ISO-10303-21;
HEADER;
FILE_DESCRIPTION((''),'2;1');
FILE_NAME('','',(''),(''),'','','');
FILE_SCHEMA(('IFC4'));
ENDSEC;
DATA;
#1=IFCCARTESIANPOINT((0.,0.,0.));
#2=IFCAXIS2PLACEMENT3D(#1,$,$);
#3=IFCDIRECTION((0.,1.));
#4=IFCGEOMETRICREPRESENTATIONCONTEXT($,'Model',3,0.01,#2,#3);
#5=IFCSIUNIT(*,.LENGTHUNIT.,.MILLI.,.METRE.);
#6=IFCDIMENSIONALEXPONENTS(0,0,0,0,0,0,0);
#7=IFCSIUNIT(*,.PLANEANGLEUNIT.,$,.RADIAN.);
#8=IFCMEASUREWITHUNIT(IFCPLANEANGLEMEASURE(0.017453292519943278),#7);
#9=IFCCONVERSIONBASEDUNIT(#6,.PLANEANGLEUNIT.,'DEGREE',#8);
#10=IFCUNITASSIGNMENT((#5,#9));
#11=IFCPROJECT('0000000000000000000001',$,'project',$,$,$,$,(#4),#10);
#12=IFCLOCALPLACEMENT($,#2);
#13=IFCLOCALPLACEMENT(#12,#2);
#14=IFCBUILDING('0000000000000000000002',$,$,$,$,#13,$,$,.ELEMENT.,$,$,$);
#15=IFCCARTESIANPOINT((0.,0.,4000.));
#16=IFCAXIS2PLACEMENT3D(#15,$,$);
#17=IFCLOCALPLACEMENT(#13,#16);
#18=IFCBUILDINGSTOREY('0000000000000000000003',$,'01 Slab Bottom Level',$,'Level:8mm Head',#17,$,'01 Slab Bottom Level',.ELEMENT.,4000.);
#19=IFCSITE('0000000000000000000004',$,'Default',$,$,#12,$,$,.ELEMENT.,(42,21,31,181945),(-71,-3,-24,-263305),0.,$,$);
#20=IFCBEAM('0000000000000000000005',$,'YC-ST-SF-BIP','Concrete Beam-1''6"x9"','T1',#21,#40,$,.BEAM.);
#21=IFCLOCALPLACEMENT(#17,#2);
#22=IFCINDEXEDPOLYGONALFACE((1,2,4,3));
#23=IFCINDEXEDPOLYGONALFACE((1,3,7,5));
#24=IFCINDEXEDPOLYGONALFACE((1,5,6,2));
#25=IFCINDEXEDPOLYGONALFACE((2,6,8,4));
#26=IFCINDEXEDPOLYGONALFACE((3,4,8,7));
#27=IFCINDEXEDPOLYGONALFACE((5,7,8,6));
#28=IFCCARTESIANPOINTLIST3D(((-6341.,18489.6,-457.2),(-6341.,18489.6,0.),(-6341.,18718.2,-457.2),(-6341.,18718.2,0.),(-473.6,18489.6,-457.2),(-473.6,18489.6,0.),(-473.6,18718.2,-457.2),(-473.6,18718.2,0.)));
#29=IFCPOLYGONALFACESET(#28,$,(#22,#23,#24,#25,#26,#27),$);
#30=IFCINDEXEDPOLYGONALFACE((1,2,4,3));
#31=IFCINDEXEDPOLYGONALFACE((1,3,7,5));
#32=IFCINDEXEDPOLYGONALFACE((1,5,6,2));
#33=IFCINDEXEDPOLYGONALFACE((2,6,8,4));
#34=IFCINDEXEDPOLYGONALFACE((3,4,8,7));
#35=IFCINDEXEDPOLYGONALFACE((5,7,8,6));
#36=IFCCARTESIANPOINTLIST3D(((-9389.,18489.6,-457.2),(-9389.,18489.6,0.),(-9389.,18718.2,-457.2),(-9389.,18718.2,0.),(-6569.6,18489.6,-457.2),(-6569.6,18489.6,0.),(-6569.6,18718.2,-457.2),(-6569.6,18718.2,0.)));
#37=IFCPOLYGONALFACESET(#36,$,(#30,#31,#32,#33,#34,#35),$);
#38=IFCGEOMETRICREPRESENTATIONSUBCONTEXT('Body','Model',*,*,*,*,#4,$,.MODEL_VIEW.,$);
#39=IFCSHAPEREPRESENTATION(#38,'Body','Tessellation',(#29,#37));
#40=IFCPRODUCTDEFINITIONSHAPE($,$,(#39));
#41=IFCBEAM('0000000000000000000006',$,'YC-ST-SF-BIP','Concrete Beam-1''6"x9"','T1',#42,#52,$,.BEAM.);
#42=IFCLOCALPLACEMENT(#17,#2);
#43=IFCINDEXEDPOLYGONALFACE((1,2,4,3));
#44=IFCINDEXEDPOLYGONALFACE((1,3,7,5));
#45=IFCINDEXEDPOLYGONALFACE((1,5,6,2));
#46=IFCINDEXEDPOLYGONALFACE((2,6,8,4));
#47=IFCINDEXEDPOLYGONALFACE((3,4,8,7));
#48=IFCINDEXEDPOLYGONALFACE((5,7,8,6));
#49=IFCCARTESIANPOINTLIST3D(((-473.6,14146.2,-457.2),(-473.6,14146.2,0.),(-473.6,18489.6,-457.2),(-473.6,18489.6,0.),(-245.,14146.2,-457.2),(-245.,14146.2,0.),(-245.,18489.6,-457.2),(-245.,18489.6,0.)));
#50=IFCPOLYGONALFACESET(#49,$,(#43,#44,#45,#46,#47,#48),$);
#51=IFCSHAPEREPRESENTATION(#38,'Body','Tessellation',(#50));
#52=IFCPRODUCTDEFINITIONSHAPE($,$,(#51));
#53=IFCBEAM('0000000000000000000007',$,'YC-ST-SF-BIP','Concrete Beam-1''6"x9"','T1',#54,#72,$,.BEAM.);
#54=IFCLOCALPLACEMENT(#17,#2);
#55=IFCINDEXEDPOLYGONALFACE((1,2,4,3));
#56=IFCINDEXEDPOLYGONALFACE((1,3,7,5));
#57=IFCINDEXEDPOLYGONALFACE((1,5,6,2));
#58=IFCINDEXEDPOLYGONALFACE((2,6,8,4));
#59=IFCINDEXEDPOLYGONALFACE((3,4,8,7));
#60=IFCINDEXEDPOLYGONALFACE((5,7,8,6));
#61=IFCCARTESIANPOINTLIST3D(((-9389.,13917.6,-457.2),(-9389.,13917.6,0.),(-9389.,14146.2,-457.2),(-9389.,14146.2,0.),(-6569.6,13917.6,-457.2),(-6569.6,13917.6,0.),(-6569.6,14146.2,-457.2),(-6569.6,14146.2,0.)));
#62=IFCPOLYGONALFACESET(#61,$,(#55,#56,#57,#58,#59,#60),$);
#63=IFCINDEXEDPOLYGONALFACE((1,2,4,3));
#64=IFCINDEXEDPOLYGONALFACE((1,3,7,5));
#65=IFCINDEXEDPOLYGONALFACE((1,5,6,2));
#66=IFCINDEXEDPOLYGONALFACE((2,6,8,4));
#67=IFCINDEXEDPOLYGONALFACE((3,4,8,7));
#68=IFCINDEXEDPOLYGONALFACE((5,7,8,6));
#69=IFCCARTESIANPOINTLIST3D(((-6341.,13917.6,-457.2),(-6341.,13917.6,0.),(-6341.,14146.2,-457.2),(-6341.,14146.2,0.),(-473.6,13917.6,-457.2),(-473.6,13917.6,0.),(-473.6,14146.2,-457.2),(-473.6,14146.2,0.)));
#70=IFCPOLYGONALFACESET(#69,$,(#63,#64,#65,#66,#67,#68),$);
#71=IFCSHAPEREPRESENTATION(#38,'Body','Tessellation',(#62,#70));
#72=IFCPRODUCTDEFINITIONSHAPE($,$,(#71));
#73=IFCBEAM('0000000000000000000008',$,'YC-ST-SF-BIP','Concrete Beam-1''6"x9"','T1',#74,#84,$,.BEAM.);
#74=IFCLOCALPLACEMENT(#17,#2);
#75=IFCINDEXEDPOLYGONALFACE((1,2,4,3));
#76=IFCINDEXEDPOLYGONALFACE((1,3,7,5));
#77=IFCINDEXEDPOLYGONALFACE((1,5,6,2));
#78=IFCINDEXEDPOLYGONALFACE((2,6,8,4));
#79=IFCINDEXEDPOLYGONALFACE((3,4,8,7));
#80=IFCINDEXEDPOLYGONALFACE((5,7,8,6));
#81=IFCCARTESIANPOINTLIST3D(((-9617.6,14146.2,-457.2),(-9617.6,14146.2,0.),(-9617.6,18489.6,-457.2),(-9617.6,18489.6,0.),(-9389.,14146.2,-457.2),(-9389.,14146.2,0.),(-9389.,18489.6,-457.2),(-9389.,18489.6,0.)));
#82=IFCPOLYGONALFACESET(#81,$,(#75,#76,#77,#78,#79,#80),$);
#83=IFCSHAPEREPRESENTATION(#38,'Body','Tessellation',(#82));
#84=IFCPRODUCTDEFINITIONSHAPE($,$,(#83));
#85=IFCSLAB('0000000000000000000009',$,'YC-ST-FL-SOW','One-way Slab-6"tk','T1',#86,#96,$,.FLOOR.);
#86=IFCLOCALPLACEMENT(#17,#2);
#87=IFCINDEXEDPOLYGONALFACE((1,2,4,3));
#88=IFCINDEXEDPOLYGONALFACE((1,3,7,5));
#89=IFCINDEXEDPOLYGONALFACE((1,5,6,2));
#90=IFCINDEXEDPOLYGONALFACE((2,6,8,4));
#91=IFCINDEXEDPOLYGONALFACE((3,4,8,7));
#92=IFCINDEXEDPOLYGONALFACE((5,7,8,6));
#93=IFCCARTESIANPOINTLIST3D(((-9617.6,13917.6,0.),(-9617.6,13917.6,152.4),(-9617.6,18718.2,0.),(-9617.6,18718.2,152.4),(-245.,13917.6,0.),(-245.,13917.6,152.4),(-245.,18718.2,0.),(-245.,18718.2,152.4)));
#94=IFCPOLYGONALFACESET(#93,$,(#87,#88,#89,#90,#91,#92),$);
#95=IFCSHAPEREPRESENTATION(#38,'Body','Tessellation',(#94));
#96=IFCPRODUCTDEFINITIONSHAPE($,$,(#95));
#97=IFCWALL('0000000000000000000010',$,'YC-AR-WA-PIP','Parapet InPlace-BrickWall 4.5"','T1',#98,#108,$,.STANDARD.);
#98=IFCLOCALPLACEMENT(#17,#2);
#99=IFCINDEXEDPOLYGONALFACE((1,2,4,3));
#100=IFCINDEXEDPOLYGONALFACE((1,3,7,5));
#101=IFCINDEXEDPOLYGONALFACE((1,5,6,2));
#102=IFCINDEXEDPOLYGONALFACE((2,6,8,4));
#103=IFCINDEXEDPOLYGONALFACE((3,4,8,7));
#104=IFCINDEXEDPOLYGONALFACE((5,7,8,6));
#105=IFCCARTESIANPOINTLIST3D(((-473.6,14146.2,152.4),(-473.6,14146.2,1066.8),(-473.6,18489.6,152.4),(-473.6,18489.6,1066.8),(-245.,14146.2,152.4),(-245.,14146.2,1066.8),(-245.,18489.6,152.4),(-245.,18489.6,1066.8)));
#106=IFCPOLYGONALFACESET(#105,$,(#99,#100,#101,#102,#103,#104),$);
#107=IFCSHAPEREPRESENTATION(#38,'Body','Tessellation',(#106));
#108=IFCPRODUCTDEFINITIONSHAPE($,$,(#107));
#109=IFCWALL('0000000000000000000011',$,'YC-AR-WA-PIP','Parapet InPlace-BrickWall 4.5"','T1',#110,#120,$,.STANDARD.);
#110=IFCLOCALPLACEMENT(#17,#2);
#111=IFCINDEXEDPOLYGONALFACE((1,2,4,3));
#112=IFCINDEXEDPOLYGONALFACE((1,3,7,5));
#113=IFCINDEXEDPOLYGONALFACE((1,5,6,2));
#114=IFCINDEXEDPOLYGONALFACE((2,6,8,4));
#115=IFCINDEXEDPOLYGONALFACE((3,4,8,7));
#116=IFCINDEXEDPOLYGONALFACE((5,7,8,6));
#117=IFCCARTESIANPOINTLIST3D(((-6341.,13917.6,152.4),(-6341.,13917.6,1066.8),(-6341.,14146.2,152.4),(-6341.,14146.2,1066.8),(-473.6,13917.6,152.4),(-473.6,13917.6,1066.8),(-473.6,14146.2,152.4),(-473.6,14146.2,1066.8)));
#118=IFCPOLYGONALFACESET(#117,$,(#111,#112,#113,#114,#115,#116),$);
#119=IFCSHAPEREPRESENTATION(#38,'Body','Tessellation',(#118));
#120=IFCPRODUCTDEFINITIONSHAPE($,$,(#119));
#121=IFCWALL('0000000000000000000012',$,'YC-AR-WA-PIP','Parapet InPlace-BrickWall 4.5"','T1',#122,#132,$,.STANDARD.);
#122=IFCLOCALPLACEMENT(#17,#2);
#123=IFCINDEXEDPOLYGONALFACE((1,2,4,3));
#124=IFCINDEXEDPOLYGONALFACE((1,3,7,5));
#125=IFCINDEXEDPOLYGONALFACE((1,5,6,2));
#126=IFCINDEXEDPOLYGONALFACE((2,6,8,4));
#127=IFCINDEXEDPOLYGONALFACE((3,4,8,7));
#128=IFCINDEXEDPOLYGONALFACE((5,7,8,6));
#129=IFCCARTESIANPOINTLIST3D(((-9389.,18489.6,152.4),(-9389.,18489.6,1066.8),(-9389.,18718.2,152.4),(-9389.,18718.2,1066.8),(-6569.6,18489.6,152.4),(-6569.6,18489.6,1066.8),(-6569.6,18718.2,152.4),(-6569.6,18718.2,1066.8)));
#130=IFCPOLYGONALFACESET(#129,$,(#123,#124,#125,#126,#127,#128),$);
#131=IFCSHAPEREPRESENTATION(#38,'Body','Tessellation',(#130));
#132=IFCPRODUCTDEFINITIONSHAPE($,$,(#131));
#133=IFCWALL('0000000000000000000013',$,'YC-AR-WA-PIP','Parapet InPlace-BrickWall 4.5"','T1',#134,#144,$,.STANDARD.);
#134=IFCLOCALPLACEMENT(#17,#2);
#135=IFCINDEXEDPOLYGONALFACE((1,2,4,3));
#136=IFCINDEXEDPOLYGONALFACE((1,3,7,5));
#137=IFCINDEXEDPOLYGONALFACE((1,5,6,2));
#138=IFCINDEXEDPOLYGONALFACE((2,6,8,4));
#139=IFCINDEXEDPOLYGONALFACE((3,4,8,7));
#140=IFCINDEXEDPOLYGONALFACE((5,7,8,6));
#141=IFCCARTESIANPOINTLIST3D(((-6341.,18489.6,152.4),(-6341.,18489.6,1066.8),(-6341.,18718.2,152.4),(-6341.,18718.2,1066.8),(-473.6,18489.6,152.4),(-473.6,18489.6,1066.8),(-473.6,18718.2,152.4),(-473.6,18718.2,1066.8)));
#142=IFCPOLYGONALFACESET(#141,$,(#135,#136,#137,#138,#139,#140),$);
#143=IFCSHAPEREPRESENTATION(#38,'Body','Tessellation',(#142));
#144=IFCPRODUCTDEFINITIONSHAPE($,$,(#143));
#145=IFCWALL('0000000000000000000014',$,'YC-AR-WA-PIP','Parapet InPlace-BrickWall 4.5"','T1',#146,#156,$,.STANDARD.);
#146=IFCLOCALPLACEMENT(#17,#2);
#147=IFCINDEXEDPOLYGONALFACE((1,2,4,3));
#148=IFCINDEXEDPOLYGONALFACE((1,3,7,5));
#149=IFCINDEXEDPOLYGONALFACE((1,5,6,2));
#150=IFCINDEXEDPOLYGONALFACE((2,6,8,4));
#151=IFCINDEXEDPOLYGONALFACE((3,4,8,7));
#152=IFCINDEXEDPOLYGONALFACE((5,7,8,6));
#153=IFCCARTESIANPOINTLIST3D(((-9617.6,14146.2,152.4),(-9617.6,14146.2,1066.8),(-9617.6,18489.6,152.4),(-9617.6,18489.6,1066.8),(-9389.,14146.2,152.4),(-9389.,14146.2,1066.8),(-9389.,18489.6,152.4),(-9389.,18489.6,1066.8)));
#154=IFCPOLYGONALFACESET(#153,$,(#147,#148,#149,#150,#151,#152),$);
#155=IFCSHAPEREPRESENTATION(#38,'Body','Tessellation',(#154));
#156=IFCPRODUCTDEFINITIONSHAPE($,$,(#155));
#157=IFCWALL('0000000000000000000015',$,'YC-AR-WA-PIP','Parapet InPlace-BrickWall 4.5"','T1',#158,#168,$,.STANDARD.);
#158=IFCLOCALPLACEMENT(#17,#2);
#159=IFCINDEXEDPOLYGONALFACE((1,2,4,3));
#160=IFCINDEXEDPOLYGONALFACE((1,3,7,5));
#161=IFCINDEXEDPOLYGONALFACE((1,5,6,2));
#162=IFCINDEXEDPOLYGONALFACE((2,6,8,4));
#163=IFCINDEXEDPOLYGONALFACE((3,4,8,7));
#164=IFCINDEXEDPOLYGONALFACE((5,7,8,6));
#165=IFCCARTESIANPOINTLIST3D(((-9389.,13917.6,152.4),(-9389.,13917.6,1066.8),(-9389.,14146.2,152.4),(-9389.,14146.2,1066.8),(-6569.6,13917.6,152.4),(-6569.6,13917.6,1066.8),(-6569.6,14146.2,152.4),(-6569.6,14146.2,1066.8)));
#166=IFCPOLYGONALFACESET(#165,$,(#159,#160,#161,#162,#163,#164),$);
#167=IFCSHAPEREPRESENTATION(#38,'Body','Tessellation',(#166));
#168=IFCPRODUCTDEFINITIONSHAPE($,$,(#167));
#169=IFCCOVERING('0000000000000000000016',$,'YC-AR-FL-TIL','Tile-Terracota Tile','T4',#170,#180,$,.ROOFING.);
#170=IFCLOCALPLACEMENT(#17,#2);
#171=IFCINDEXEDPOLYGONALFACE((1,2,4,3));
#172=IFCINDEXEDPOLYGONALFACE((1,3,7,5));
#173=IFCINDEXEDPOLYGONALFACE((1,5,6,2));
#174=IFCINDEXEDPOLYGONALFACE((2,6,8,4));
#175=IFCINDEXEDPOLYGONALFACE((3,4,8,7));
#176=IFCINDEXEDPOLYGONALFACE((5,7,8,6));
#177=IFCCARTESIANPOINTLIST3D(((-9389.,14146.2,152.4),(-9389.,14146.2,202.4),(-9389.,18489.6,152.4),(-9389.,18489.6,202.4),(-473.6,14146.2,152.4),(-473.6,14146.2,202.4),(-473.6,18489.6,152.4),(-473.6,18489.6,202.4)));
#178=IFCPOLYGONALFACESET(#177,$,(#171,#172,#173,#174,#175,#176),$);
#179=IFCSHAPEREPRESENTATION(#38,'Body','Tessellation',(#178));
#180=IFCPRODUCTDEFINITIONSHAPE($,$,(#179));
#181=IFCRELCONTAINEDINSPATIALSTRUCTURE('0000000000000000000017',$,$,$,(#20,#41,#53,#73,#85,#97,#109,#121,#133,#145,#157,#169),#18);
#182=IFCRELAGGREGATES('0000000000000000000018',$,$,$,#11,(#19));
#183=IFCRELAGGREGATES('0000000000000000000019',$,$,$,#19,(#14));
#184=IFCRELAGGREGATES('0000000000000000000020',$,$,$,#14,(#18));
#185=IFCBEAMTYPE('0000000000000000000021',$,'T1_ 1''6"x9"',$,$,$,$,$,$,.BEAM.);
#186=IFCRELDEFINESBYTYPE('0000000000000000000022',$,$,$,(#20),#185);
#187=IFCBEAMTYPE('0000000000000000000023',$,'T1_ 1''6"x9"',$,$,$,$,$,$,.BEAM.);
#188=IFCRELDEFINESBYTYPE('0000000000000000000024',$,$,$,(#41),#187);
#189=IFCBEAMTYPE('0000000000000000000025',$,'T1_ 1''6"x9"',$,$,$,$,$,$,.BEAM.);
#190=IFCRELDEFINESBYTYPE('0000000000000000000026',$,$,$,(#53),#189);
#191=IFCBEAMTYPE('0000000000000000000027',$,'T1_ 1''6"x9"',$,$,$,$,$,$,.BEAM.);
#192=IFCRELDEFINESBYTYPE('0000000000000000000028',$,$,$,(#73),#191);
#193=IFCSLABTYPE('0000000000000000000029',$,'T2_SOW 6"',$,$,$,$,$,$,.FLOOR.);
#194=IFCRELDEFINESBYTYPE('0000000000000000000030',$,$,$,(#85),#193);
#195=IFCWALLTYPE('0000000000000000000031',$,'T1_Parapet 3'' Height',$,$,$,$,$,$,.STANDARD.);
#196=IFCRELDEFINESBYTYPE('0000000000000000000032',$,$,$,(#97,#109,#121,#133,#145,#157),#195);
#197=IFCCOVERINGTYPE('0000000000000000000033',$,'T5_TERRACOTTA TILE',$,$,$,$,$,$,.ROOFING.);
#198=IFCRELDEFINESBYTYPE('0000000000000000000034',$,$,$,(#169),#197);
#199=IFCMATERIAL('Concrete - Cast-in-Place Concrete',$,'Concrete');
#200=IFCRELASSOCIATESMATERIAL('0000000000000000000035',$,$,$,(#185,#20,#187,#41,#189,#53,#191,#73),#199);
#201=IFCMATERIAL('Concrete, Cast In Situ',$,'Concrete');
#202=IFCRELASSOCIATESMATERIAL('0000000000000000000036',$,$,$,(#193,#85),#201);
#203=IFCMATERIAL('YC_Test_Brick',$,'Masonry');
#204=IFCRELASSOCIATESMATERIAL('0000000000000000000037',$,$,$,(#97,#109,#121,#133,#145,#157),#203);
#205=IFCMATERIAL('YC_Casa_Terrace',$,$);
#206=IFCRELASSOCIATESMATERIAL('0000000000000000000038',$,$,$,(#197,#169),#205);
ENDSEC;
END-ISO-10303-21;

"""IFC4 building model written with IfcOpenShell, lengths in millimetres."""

from ifc_helpers import new_model, entity, si_unit, converted_unit, direction, frame, origin, place, context, subcontext, project, spatial, indexed_curve, outline, extrude, source, transform, mapped, material, type_object, type_shapes, element, save


model = new_model("IFC4")

# Units and contexts
model_context = context("Model", 3, precision=0.01, world=origin(), true_north=direction((0.0, 1.0)))
body_context = subcontext(model_context, "Body", "Model", "MODEL_VIEW")
ifc_project = project(units=[si_unit("LENGTHUNIT", "METRE", prefix="MILLI"), converted_unit("PLANEANGLEUNIT", "DEGREE", entity("IfcPlaneAngleMeasure", 0.017453292519943278), si_unit("PLANEANGLEUNIT", "RADIAN"), dimensions=[0, 0, 0, 0, 0, 0, 0])], contexts=[model_context])

# Site, building, storey
site_placement = place(None, origin())
site = spatial("IfcSite", under=ifc_project, at=site_placement, Name="Default", CompositionType="ELEMENT", RefLatitude=(42, 21, 31, 181945), RefLongitude=(-71, -3, -24, -263305), RefElevation=0.0)
building_placement = place(site_placement, origin())
building = spatial("IfcBuilding", under=site, at=building_placement, CompositionType="ELEMENT")
storey_placement = place(building_placement, frame((0.0, 0.0, 4000.0)))
storey = spatial("IfcBuildingStorey", under=building, at=storey_placement, Name="01 Slab Bottom Level", ObjectType="Level:8mm Head", LongName="01 Slab Bottom Level", CompositionType="ELEMENT", Elevation=4000.0)

# Beams
ifc_material_1 = material(Name="Concrete - Cast-in-Place Concrete", Category="Concrete")
beam_type_1 = type_object("IfcBeamType", Name="T1_ 1'6\"x9\"", PredefinedType="BEAM", material=ifc_material_1)
shared_shape_1 = source(origin(), body_context, "Body", "SweptSolid", [
    extrude(outline(indexed_curve([(-228.6, -114.3), (228.6, -114.3), (228.6, 114.3), (-228.6, 114.3), (-228.6, -114.3)], self_intersect=False)), frame((-6341.0, 18603.9, 3771.4), z_axis=(1.0, 0.0, 0.0), x_axis=(0.0, 0.0, -1.0)), (0.0, 0.0, 1.0), 5867.4),
    extrude(outline(indexed_curve([(-228.6, -114.3), (228.6, -114.3), (228.6, 114.3), (-228.6, 114.3), (-228.6, -114.3)], self_intersect=False)), frame((-9389.0, 18603.9, 3771.4), z_axis=(1.0, 0.0, 0.0), x_axis=(0.0, 0.0, -1.0)), (0.0, 0.0, 1.0), 2819.4),
])
type_shapes(beam_type_1, [shared_shape_1])
beam_1_placement = place(storey_placement, frame((0.0, 0.0, -4000.0)))
element("IfcBeam", 1, at=beam_1_placement, inside=storey, type_object=beam_type_1, material=ifc_material_1, Name="YC-ST-SF-BIP", Description="Concrete Beam-1'6\"x9\"", ObjectType="T1", PredefinedType="BEAM", context=body_context, shape_type="MappedRepresentation", body=[
    mapped(shared_shape_1, transform((0.0, 0.0, 0.0), scale=1.0)),
])
beam_type_2 = type_object("IfcBeamType", Name="T1_ 1'6\"x9\"", PredefinedType="BEAM", material=ifc_material_1)
shared_shape_2 = source(origin(), body_context, "Body", "SweptSolid", [
    extrude(outline(indexed_curve([(-114.3, -228.6), (114.3, -228.6), (114.3, 228.6), (-114.3, 228.6), (-114.3, -228.6)], self_intersect=False)), frame((-359.3, 18489.6, 3771.4), z_axis=(0.0, -1.0, 0.0), x_axis=(-1.0, 0.0, 0.0)), (0.0, 0.0, 1.0), 4343.4),
])
type_shapes(beam_type_2, [shared_shape_2])
beam_2_placement = place(storey_placement, frame((0.0, 0.0, -4000.0)))
element("IfcBeam", 2, at=beam_2_placement, inside=storey, type_object=beam_type_2, material=ifc_material_1, Name="YC-ST-SF-BIP", Description="Concrete Beam-1'6\"x9\"", ObjectType="T1", PredefinedType="BEAM", context=body_context, shape_type="MappedRepresentation", body=[
    mapped(shared_shape_2, transform((0.0, 0.0, 0.0), scale=1.0)),
])
beam_type_3 = type_object("IfcBeamType", Name="T1_ 1'6\"x9\"", PredefinedType="BEAM", material=ifc_material_1)
shared_shape_3 = source(origin(), body_context, "Body", "SweptSolid", [
    extrude(outline(indexed_curve([(-228.6, -114.3), (228.6, -114.3), (228.6, 114.3), (-228.6, 114.3), (-228.6, -114.3)], self_intersect=False)), frame((-6569.6, 14031.9, 3771.4), z_axis=(-1.0, 0.0, 0.0), x_axis=(0.0, 0.0, -1.0)), (0.0, 0.0, 1.0), 2819.4),
    extrude(outline(indexed_curve([(-228.6, -114.3), (228.6, -114.3), (228.6, 114.3), (-228.6, 114.3), (-228.6, -114.3)], self_intersect=False)), frame((-473.6, 14031.9, 3771.4), z_axis=(-1.0, 0.0, 0.0), x_axis=(0.0, 0.0, -1.0)), (0.0, 0.0, 1.0), 5867.4),
])
type_shapes(beam_type_3, [shared_shape_3])
beam_3_placement = place(storey_placement, frame((0.0, 0.0, -4000.0)))
element("IfcBeam", 3, at=beam_3_placement, inside=storey, type_object=beam_type_3, material=ifc_material_1, Name="YC-ST-SF-BIP", Description="Concrete Beam-1'6\"x9\"", ObjectType="T1", PredefinedType="BEAM", context=body_context, shape_type="MappedRepresentation", body=[
    mapped(shared_shape_3, transform((0.0, 0.0, 0.0), scale=1.0)),
])
beam_type_4 = type_object("IfcBeamType", Name="T1_ 1'6\"x9\"", PredefinedType="BEAM", material=ifc_material_1)
shared_shape_4 = source(origin(), body_context, "Body", "SweptSolid", [
    extrude(outline(indexed_curve([(-114.3, -228.6), (114.3, -228.6), (114.3, 228.6), (-114.3, 228.6), (-114.3, -228.6)], self_intersect=False)), frame((-9503.3, 14146.2, 3771.4), z_axis=(0.0, 1.0, 0.0), x_axis=(-1.0, 0.0, 0.0)), (0.0, 0.0, 1.0), 4343.4),
])
type_shapes(beam_type_4, [shared_shape_4])
beam_4_placement = place(storey_placement, frame((0.0, 0.0, -4000.0)))
element("IfcBeam", 4, at=beam_4_placement, inside=storey, type_object=beam_type_4, material=ifc_material_1, Name="YC-ST-SF-BIP", Description="Concrete Beam-1'6\"x9\"", ObjectType="T1", PredefinedType="BEAM", context=body_context, shape_type="MappedRepresentation", body=[
    mapped(shared_shape_4, transform((0.0, 0.0, 0.0), scale=1.0)),
])

# Slab
ifc_material_2 = material(Name="Concrete, Cast In Situ", Category="Concrete")
slab_type = type_object("IfcSlabType", Name="T2_SOW 6\"", PredefinedType="FLOOR", material=ifc_material_2)
slab_placement = place(storey_placement, origin())
element("IfcSlab", 5, at=slab_placement, inside=storey, type_object=slab_type, material=ifc_material_2, Name="YC-ST-FL-SOW", Description="One-way Slab-6\"tk", ObjectType="T1", PredefinedType="FLOOR", context=body_context, shape_type="SweptSolid", body=[
    extrude(outline(indexed_curve([(-2400.3, -4686.3), (2400.3, -4686.3), (2400.3, 4686.3), (-2400.3, 4686.3), (-2400.3, -4686.3)], self_intersect=False)), frame((-4931.3, 16317.9, 152.4), z_axis=(0.0, 0.0, -1.0), x_axis=(0.0, 1.0, 0.0)), (0.0, 0.0, 1.0), 152.4),
])

# Walls
ifc_material_3 = material(Name="YC_Test_Brick", Category="Masonry")
wall_type = type_object("IfcWallType", Name="T1_Parapet 3' Height", PredefinedType="STANDARD")
wall_1_placement = place(storey_placement, frame((-359.3, 18489.6, 152.4), z_axis=(0.0, 0.0, 1.0), x_axis=(0.0, -1.0, 0.0)))
element("IfcWall", 6, at=wall_1_placement, inside=storey, type_object=wall_type, material=ifc_material_3, Name="YC-AR-WA-PIP", Description="Parapet InPlace-BrickWall 4.5\"", ObjectType="T1", PredefinedType="STANDARD", context=body_context, shape_type="SweptSolid", body=[
    extrude(outline(indexed_curve([(4343.4, 114.3), (0.0, 114.3), (0.0, -114.3), (4343.4, -114.3), (4343.4, 114.3)], self_intersect=False)), origin(), (0.0, 0.0, 1.0), 914.4),
])
wall_2_placement = place(storey_placement, frame((-473.6, 14031.9, 152.4), z_axis=(0.0, 0.0, 1.0), x_axis=(-1.0, 0.0, 0.0)))
element("IfcWall", 7, at=wall_2_placement, inside=storey, type_object=wall_type, material=ifc_material_3, Name="YC-AR-WA-PIP", Description="Parapet InPlace-BrickWall 4.5\"", ObjectType="T1", PredefinedType="STANDARD", context=body_context, shape_type="SweptSolid", body=[
    extrude(outline(indexed_curve([(5867.4, 114.3), (0.0, 114.3), (0.0, -114.3), (5867.4, -114.3), (5867.4, 114.3)], self_intersect=False)), origin(), (0.0, 0.0, 1.0), 914.4),
])
wall_3_placement = place(storey_placement, frame((-9389.0, 18603.9, 152.4)))
element("IfcWall", 8, at=wall_3_placement, inside=storey, type_object=wall_type, material=ifc_material_3, Name="YC-AR-WA-PIP", Description="Parapet InPlace-BrickWall 4.5\"", ObjectType="T1", PredefinedType="STANDARD", context=body_context, shape_type="SweptSolid", body=[
    extrude(outline(indexed_curve([(2819.4, 114.3), (0.0, 114.3), (0.0, -114.3), (2819.4, -114.3), (2819.4, 114.3)], self_intersect=False)), origin(), (0.0, 0.0, 1.0), 914.4),
])
wall_4_placement = place(storey_placement, frame((-6341.0, 18603.9, 152.4)))
element("IfcWall", 9, at=wall_4_placement, inside=storey, type_object=wall_type, material=ifc_material_3, Name="YC-AR-WA-PIP", Description="Parapet InPlace-BrickWall 4.5\"", ObjectType="T1", PredefinedType="STANDARD", context=body_context, shape_type="SweptSolid", body=[
    extrude(outline(indexed_curve([(5867.4, 114.3), (0.0, 114.3), (0.0, -114.3), (5867.4, -114.3), (5867.4, 114.3)], self_intersect=False)), origin(), (0.0, 0.0, 1.0), 914.4),
])
wall_5_placement = place(storey_placement, frame((-9503.3, 18489.6, 152.4), z_axis=(0.0, 0.0, 1.0), x_axis=(0.0, -1.0, 0.0)))
element("IfcWall", 10, at=wall_5_placement, inside=storey, type_object=wall_type, material=ifc_material_3, Name="YC-AR-WA-PIP", Description="Parapet InPlace-BrickWall 4.5\"", ObjectType="T1", PredefinedType="STANDARD", context=body_context, shape_type="SweptSolid", body=[
    extrude(outline(indexed_curve([(4343.4, 114.3), (0.0, 114.3), (0.0, -114.3), (4343.4, -114.3), (4343.4, 114.3)], self_intersect=False)), origin(), (0.0, 0.0, 1.0), 914.4),
])
wall_6_placement = place(storey_placement, frame((-9389.0, 14031.9, 152.4)))
element("IfcWall", 11, at=wall_6_placement, inside=storey, type_object=wall_type, material=ifc_material_3, Name="YC-AR-WA-PIP", Description="Parapet InPlace-BrickWall 4.5\"", ObjectType="T1", PredefinedType="STANDARD", context=body_context, shape_type="SweptSolid", body=[
    extrude(outline(indexed_curve([(2819.4, 114.3), (0.0, 114.3), (0.0, -114.3), (2819.4, -114.3), (2819.4, 114.3)], self_intersect=False)), origin(), (0.0, 0.0, 1.0), 914.4),
])

# Covering
ifc_material_4 = material(Name="YC_Casa_Terrace")
covering_type = type_object("IfcCoveringType", Name="T5_TERRACOTTA TILE", PredefinedType="ROOFING", material=ifc_material_4)
covering_placement = place(storey_placement, origin())
element("IfcCovering", 12, at=covering_placement, inside=storey, type_object=covering_type, material=ifc_material_4, Name="YC-AR-FL-TIL", Description="Tile-Terracota Tile", ObjectType="T4", PredefinedType="ROOFING", context=body_context, shape_type="SweptSolid", body=[
    extrude(outline(indexed_curve([(-2171.7, -4457.7), (2171.7, -4457.7), (2171.7, 4457.7), (-2171.7, 4457.7), (-2171.7, -4457.7)], self_intersect=False)), frame((-4931.3, 16317.9, 202.4), z_axis=(0.0, 0.0, -1.0), x_axis=(0.0, 1.0, 0.0)), (0.0, 0.0, 1.0), 50.0),
])

save(model, "model.ifc")
